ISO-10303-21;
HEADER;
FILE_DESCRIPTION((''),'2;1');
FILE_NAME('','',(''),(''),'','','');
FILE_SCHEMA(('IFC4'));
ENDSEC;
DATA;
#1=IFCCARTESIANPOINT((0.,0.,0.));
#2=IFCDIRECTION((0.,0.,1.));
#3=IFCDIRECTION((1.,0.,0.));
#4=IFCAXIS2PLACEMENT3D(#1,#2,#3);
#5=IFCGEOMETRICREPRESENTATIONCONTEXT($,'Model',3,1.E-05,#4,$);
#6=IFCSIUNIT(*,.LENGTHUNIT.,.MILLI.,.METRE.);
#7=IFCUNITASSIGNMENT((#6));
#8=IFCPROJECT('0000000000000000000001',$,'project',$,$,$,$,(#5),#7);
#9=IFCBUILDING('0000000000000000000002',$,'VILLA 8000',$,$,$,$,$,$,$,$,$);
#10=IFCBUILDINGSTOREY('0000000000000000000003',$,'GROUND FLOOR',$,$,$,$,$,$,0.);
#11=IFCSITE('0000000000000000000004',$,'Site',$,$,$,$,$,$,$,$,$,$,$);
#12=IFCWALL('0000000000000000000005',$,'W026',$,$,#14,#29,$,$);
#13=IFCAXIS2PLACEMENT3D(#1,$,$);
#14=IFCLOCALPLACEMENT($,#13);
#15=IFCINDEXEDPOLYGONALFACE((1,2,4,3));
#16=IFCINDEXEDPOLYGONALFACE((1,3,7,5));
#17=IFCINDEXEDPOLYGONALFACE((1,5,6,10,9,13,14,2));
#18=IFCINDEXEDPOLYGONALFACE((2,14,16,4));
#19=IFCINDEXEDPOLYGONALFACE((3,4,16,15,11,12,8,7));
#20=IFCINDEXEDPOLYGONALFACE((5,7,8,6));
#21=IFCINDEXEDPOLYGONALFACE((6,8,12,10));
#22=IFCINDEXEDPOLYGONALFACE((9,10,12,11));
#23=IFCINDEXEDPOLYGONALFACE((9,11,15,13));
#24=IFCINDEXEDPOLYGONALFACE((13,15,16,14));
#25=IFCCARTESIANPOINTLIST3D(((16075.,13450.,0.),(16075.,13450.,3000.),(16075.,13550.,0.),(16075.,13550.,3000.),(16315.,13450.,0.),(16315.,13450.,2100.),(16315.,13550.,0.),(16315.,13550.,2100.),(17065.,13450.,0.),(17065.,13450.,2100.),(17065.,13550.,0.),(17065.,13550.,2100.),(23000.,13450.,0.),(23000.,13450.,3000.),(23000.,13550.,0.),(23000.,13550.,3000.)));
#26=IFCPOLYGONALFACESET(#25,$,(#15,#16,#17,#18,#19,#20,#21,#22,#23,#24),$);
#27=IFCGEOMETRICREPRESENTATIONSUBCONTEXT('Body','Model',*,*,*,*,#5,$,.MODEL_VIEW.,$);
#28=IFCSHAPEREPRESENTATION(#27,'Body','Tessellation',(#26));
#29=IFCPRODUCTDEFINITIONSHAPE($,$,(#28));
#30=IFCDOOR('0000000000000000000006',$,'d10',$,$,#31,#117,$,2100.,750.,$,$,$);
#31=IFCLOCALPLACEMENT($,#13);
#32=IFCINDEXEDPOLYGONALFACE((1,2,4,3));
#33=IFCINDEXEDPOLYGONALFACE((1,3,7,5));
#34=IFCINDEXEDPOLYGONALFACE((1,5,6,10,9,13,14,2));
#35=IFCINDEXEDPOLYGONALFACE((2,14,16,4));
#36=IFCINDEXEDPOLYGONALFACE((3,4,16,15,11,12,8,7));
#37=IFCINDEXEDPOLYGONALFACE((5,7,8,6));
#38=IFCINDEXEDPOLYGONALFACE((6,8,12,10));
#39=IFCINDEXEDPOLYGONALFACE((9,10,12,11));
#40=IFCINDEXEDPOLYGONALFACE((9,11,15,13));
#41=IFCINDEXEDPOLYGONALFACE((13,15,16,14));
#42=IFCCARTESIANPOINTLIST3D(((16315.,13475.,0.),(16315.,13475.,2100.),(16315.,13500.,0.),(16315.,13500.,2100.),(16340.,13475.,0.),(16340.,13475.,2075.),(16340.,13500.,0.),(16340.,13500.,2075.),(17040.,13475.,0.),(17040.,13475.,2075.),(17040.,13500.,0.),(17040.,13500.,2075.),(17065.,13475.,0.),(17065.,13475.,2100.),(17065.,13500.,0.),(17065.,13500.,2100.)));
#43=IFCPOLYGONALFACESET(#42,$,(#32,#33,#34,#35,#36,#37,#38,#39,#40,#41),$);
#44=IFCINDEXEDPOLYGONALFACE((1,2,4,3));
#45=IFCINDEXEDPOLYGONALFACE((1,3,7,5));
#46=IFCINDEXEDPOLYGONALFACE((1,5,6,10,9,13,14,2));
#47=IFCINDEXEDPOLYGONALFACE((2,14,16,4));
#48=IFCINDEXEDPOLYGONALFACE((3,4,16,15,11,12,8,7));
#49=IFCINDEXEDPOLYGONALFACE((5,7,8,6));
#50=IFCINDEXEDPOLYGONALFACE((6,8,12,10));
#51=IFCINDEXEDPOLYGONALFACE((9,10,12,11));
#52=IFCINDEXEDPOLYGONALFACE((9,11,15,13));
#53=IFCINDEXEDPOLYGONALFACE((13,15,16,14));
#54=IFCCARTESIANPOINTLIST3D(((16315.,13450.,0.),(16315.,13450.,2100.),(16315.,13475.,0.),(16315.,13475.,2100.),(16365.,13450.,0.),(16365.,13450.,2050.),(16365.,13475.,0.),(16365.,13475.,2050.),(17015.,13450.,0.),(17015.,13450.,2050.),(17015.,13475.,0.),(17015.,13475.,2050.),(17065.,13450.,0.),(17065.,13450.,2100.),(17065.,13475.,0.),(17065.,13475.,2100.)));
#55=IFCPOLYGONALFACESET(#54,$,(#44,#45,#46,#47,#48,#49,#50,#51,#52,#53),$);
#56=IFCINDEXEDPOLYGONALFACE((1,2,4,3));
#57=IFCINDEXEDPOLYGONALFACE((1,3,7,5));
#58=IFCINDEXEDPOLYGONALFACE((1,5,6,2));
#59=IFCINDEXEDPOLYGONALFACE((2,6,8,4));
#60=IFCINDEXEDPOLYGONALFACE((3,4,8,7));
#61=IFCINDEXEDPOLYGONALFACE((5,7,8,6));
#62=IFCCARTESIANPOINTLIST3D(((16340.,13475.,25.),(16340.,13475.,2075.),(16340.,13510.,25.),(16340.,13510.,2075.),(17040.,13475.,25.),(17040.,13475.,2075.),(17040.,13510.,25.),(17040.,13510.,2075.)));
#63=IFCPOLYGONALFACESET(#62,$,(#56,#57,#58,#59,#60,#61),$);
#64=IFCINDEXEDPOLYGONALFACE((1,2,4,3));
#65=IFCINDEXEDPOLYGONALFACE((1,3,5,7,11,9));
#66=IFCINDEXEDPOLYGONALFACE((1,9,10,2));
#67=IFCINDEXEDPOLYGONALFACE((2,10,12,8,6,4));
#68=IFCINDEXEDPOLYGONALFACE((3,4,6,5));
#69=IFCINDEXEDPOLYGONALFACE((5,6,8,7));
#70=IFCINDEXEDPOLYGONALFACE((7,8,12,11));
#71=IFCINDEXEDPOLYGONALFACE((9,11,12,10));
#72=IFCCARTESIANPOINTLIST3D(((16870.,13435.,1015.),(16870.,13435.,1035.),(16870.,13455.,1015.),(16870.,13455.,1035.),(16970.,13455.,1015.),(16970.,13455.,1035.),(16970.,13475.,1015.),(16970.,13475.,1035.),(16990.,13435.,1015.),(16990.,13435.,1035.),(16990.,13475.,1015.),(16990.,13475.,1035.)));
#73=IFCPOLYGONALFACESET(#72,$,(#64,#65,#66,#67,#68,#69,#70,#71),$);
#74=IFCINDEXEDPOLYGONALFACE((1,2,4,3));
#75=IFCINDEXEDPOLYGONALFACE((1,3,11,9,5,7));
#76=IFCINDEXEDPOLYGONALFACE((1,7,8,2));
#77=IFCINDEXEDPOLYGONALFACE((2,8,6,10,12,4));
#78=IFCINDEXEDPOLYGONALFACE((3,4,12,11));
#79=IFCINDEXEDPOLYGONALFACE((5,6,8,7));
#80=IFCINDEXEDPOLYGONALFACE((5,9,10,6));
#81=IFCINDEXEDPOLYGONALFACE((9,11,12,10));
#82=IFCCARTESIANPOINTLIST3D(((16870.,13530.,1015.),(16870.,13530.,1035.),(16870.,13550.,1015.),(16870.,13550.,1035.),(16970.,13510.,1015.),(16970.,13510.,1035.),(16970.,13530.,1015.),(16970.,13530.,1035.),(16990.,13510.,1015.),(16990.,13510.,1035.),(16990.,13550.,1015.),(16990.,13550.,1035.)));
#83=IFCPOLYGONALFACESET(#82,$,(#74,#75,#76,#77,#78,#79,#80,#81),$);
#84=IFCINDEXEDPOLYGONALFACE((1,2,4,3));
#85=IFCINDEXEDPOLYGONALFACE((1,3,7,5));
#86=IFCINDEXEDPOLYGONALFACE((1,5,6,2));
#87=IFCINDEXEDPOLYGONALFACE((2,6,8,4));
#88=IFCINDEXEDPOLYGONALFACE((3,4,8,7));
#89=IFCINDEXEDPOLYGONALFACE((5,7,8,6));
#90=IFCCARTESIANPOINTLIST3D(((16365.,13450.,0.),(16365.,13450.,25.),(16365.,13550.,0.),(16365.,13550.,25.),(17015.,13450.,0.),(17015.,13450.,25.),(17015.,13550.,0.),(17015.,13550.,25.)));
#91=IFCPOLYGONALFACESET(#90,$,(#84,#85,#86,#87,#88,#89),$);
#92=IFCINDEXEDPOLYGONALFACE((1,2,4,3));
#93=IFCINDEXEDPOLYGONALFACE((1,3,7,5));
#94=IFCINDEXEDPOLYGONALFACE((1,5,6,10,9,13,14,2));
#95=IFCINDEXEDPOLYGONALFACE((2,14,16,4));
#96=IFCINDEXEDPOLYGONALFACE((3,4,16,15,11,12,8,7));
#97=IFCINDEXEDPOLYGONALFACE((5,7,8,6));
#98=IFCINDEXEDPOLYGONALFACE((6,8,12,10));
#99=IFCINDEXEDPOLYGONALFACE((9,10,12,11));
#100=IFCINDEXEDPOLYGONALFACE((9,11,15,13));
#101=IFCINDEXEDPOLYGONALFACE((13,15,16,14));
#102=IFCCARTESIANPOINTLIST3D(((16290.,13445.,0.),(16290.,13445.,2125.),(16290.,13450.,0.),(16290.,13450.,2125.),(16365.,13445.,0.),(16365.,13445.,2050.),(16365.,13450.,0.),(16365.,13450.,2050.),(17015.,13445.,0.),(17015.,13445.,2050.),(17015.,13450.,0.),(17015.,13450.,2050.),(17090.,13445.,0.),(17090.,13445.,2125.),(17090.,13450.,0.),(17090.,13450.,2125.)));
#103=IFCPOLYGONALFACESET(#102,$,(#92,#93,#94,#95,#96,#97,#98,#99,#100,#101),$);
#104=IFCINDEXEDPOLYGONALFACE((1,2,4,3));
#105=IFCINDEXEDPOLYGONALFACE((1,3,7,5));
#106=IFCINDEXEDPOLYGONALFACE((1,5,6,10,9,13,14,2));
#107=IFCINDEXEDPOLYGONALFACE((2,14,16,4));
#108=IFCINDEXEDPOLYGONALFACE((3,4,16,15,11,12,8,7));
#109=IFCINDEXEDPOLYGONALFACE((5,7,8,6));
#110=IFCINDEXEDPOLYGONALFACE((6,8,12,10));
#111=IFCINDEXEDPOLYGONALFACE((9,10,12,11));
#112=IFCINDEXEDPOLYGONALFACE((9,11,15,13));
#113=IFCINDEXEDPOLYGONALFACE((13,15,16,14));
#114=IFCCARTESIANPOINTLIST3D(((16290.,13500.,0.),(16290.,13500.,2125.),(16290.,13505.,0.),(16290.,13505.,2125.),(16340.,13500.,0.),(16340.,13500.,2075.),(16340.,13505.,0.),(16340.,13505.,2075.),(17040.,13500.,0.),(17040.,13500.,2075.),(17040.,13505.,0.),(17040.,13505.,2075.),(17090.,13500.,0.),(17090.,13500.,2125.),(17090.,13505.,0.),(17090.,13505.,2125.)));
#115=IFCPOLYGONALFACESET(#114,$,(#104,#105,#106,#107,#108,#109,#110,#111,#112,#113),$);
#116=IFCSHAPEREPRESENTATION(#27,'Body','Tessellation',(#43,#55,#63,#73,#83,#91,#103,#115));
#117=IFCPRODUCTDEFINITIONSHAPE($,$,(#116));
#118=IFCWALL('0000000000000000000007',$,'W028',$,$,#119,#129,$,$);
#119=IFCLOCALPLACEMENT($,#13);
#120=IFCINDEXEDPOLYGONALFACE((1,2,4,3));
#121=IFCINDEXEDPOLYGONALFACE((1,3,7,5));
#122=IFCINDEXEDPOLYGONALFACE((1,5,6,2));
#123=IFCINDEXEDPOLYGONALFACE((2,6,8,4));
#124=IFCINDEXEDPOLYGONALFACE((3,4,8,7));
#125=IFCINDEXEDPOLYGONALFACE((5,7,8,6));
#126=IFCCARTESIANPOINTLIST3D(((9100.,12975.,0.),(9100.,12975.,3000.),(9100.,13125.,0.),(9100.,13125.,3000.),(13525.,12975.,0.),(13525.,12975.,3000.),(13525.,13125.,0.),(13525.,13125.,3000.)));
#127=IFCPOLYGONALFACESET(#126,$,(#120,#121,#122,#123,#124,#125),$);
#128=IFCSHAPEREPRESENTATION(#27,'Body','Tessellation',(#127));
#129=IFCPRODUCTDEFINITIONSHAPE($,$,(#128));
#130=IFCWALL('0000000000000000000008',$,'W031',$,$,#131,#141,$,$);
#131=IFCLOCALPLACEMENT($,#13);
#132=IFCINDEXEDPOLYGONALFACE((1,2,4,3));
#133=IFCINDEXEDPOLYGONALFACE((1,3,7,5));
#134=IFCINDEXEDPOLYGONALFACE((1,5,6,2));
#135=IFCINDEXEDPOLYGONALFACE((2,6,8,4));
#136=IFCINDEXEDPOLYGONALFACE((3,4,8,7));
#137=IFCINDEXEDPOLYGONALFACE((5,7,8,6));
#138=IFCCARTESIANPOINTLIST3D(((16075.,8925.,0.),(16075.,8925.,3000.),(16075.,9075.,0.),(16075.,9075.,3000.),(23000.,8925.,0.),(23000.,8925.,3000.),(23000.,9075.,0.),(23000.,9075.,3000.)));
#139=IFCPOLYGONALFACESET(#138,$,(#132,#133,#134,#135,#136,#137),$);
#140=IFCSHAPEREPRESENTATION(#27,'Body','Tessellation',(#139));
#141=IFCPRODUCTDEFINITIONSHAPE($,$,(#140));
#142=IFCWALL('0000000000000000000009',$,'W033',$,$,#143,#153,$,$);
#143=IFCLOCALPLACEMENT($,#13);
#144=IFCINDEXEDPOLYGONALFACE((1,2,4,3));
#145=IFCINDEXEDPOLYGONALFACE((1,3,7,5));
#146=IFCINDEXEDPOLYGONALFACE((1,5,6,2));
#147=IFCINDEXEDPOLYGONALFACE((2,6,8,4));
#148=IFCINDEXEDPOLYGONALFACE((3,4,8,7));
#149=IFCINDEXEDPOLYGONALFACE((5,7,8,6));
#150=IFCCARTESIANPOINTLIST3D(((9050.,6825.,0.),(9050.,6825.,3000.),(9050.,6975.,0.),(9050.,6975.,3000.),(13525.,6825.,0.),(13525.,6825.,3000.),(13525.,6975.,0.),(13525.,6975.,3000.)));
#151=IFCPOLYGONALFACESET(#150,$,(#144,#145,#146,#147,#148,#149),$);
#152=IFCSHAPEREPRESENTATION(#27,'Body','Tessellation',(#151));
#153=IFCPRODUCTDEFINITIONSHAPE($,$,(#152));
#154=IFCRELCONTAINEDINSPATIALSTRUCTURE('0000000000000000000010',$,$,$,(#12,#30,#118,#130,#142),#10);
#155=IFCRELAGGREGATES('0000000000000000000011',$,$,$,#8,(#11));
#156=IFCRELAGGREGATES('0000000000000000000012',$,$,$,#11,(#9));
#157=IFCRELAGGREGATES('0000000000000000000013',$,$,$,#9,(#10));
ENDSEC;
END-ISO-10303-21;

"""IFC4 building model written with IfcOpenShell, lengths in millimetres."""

from ifc_helpers import new_model, si_unit, frame, origin_with_axes, place, context, subcontext, project, spatial, line, indexed_curve, outline, extrude, element, fill, save


model = new_model("IFC4")

# Units and contexts
model_context = context("Model", 3, precision=1e-05, world=origin_with_axes())
body_context = subcontext(model_context, "Body", "Model", "MODEL_VIEW")
ifc_project = project(units=[si_unit("LENGTHUNIT", "METRE", prefix="MILLI")], contexts=[model_context])

# Site, building, storey
site = spatial("IfcSite", under=ifc_project, Name="Site")
building = spatial("IfcBuilding", under=site, Name="VILLA 8000")
storey = spatial("IfcBuildingStorey", under=building, Name="GROUND FLOOR", Elevation=0.0)

# Wall, opening, door
wall_1_placement = place(None, frame((16075.0, 13500.0, 0.0), z_axis=(0.0, 0.0, 1.0), x_axis=(1.0, 0.0, 0.0)))
wall_1 = element("IfcWall", 1, at=wall_1_placement, inside=storey, Name="W026", context=body_context, shape_type="SweptSolid", body=[
    extrude(outline(indexed_curve([(0.0, 0.0), (0.0, 100.0), (6925.0, 100.0), (6925.0, 0.0), (0.0, 0.0)], self_intersect=False)), frame((0.0, -50.0, 0.0), z_axis=(0.0, 0.0, 1.0), x_axis=(1.0, 0.0, 0.0)), (0.0, 0.0, 1.0), 3000.0),
])
opening_1_placement = place(wall_1_placement, frame((240.0, 0.0, 0.0), z_axis=(0.0, 0.0, 1.0), x_axis=(1.0, 0.0, 0.0)))
opening_1 = element("IfcOpeningElement", 2, at=opening_1_placement, cuts=wall_1, context=body_context, shape_type="SweptSolid", body=[
    extrude(outline(indexed_curve([(0.0, 0.0), (0.0, 200.0), (750.0, 200.0), (750.0, 0.0), (0.0, 0.0)], self_intersect=False)), frame((0.0, -100.0, 0.0), z_axis=(0.0, 0.0, 1.0), x_axis=(1.0, 0.0, 0.0)), (0.0, 0.0, 1.0), 2100.0),
])
door_1_placement = place(None, frame((16315.0, 13450.0, 0.0), z_axis=(0.0, 0.0, 1.0), x_axis=(1.0, 0.0, 0.0)))
door_1 = element("IfcDoor", 3, at=door_1_placement, inside=storey, Name="d10", OverallHeight=2100.0, OverallWidth=750.0, context=body_context, shape_type="SweptSolid", body=[
    extrude(outline(indexed_curve([(0.0, 0.0), (0.0, 2100.0), (750.0, 2100.0), (750.0, 0.0), (725.0, 0.0), (725.0, 2075.0), (25.0, 2075.0), (25.0, 0.0)], segments=[line(1, 2, 3, 4, 5, 6, 7, 8, 1)])), frame((0.0, 25.0, 0.0), z_axis=(0.0, -1.0, 0.0), x_axis=(1.0, 0.0, 0.0)), (0.0, 0.0, -1.0), 25.0),
    extrude(outline(indexed_curve([(0.0, 0.0), (0.0, 2100.0), (750.0, 2100.0), (750.0, 0.0), (700.0, 0.0), (700.0, 2050.0), (50.0, 2050.0), (50.0, 0.0)], segments=[line(1, 2, 3, 4, 5, 6, 7, 8, 1)])), frame((0.0, 0.0, 0.0), z_axis=(0.0, -1.0, 0.0), x_axis=(1.0, 0.0, 0.0)), (0.0, 0.0, -1.0), 25.0),
    extrude(outline(indexed_curve([(0.0, 0.0), (700.0, 0.0), (700.0, 35.0), (0.0, 35.0)], segments=[line(1, 2, 3, 4, 1)])), frame((25.0, 25.0, 25.0), z_axis=(0.0, 0.0, 1.0), x_axis=(1.0, 0.0, 0.0)), (0.0, 0.0, 1.0), 2050.0),
    extrude(outline(indexed_curve([(0.0, 0.0), (0.0, -40.0), (-120.0, -40.0), (-120.0, -20.0), (-20.0, -20.0), (-20.0, 0.0)], segments=[line(1, 2, 3, 4, 5, 6, 1)])), frame((675.0, 25.0, 1015.0), z_axis=(0.0, 0.0, 1.0), x_axis=(1.0, 0.0, 0.0)), (0.0, 0.0, 1.0), 20.0),
    extrude(outline(indexed_curve([(0.0, 0.0), (0.0, 40.0), (-120.0, 40.0), (-120.0, 20.0), (-20.0, 20.0), (-20.0, 0.0)], segments=[line(1, 2, 3, 4, 5, 6, 1)])), frame((675.0, 60.0, 1015.0), z_axis=(0.0, 0.0, 1.0), x_axis=(1.0, 0.0, 0.0)), (0.0, 0.0, 1.0), 20.0),
    extrude(outline(indexed_curve([(0.0, 0.0), (650.0, 0.0), (650.0, 100.0), (0.0, 100.0)], segments=[line(1, 2, 3, 4, 1)])), frame((50.0, 0.0, 0.0), z_axis=(0.0, 0.0, 1.0), x_axis=(1.0, 0.0, 0.0)), (0.0, 0.0, 1.0), 25.0),
    extrude(outline(indexed_curve([(0.0, 0.0), (0.0, 2125.0), (800.0, 2125.0), (800.0, 0.0), (725.0, 0.0), (725.0, 2050.0), (75.0, 2050.0), (75.0, 0.0)], segments=[line(1, 2, 3, 4, 5, 6, 7, 8, 1)])), frame((-25.0, -5.0, 0.0), z_axis=(0.0, -1.0, 0.0), x_axis=(1.0, 0.0, 0.0)), (0.0, 0.0, -1.0), 5.0),
    extrude(outline(indexed_curve([(0.0, 0.0), (0.0, 2125.0), (800.0, 2125.0), (800.0, 0.0), (750.0, 0.0), (750.0, 2075.0), (50.0, 2075.0), (50.0, 0.0)], segments=[line(1, 2, 3, 4, 5, 6, 7, 8, 1)])), frame((-25.0, 50.0, 0.0), z_axis=(0.0, -1.0, 0.0), x_axis=(1.0, 0.0, 0.0)), (0.0, 0.0, -1.0), 5.0),
])
fill(opening_1, door_1)

# Walls
wall_2_placement = place(None, frame((9100.0, 13050.0, 0.0), z_axis=(0.0, 0.0, 1.0), x_axis=(1.0, 0.0, 0.0)))
element("IfcWall", 4, at=wall_2_placement, inside=storey, Name="W028", context=body_context, shape_type="SweptSolid", body=[
    extrude(outline(indexed_curve([(0.0, 0.0), (0.0, 150.0), (4425.0, 150.0), (4425.0, 0.0), (0.0, 0.0)], self_intersect=False)), frame((0.0, -75.0, 0.0), z_axis=(0.0, 0.0, 1.0), x_axis=(1.0, 0.0, 0.0)), (0.0, 0.0, 1.0), 3000.0),
])
wall_3_placement = place(None, frame((16075.0, 9000.0, 0.0), z_axis=(0.0, 0.0, 1.0), x_axis=(1.0, 0.0, 0.0)))
element("IfcWall", 5, at=wall_3_placement, inside=storey, Name="W031", context=body_context, shape_type="SweptSolid", body=[
    extrude(outline(indexed_curve([(0.0, 0.0), (0.0, 150.0), (6925.0, 150.0), (6925.0, 0.0), (0.0, 0.0)], self_intersect=False)), frame((0.0, -75.0, 0.0), z_axis=(0.0, 0.0, 1.0), x_axis=(1.0, 0.0, 0.0)), (0.0, 0.0, 1.0), 3000.0),
])
wall_4_placement = place(None, frame((9050.0, 6900.0, 0.0), z_axis=(0.0, 0.0, 1.0), x_axis=(1.0, 0.0, 0.0)))
element("IfcWall", 6, at=wall_4_placement, inside=storey, Name="W033", context=body_context, shape_type="SweptSolid", body=[
    extrude(outline(indexed_curve([(0.0, 0.0), (0.0, 150.0), (4475.0, 150.0), (4475.0, 0.0), (0.0, 0.0)], self_intersect=False)), frame((0.0, -75.0, 0.0), z_axis=(0.0, 0.0, 1.0), x_axis=(1.0, 0.0, 0.0)), (0.0, 0.0, 1.0), 3000.0),
])

save(model, "model.ifc")
